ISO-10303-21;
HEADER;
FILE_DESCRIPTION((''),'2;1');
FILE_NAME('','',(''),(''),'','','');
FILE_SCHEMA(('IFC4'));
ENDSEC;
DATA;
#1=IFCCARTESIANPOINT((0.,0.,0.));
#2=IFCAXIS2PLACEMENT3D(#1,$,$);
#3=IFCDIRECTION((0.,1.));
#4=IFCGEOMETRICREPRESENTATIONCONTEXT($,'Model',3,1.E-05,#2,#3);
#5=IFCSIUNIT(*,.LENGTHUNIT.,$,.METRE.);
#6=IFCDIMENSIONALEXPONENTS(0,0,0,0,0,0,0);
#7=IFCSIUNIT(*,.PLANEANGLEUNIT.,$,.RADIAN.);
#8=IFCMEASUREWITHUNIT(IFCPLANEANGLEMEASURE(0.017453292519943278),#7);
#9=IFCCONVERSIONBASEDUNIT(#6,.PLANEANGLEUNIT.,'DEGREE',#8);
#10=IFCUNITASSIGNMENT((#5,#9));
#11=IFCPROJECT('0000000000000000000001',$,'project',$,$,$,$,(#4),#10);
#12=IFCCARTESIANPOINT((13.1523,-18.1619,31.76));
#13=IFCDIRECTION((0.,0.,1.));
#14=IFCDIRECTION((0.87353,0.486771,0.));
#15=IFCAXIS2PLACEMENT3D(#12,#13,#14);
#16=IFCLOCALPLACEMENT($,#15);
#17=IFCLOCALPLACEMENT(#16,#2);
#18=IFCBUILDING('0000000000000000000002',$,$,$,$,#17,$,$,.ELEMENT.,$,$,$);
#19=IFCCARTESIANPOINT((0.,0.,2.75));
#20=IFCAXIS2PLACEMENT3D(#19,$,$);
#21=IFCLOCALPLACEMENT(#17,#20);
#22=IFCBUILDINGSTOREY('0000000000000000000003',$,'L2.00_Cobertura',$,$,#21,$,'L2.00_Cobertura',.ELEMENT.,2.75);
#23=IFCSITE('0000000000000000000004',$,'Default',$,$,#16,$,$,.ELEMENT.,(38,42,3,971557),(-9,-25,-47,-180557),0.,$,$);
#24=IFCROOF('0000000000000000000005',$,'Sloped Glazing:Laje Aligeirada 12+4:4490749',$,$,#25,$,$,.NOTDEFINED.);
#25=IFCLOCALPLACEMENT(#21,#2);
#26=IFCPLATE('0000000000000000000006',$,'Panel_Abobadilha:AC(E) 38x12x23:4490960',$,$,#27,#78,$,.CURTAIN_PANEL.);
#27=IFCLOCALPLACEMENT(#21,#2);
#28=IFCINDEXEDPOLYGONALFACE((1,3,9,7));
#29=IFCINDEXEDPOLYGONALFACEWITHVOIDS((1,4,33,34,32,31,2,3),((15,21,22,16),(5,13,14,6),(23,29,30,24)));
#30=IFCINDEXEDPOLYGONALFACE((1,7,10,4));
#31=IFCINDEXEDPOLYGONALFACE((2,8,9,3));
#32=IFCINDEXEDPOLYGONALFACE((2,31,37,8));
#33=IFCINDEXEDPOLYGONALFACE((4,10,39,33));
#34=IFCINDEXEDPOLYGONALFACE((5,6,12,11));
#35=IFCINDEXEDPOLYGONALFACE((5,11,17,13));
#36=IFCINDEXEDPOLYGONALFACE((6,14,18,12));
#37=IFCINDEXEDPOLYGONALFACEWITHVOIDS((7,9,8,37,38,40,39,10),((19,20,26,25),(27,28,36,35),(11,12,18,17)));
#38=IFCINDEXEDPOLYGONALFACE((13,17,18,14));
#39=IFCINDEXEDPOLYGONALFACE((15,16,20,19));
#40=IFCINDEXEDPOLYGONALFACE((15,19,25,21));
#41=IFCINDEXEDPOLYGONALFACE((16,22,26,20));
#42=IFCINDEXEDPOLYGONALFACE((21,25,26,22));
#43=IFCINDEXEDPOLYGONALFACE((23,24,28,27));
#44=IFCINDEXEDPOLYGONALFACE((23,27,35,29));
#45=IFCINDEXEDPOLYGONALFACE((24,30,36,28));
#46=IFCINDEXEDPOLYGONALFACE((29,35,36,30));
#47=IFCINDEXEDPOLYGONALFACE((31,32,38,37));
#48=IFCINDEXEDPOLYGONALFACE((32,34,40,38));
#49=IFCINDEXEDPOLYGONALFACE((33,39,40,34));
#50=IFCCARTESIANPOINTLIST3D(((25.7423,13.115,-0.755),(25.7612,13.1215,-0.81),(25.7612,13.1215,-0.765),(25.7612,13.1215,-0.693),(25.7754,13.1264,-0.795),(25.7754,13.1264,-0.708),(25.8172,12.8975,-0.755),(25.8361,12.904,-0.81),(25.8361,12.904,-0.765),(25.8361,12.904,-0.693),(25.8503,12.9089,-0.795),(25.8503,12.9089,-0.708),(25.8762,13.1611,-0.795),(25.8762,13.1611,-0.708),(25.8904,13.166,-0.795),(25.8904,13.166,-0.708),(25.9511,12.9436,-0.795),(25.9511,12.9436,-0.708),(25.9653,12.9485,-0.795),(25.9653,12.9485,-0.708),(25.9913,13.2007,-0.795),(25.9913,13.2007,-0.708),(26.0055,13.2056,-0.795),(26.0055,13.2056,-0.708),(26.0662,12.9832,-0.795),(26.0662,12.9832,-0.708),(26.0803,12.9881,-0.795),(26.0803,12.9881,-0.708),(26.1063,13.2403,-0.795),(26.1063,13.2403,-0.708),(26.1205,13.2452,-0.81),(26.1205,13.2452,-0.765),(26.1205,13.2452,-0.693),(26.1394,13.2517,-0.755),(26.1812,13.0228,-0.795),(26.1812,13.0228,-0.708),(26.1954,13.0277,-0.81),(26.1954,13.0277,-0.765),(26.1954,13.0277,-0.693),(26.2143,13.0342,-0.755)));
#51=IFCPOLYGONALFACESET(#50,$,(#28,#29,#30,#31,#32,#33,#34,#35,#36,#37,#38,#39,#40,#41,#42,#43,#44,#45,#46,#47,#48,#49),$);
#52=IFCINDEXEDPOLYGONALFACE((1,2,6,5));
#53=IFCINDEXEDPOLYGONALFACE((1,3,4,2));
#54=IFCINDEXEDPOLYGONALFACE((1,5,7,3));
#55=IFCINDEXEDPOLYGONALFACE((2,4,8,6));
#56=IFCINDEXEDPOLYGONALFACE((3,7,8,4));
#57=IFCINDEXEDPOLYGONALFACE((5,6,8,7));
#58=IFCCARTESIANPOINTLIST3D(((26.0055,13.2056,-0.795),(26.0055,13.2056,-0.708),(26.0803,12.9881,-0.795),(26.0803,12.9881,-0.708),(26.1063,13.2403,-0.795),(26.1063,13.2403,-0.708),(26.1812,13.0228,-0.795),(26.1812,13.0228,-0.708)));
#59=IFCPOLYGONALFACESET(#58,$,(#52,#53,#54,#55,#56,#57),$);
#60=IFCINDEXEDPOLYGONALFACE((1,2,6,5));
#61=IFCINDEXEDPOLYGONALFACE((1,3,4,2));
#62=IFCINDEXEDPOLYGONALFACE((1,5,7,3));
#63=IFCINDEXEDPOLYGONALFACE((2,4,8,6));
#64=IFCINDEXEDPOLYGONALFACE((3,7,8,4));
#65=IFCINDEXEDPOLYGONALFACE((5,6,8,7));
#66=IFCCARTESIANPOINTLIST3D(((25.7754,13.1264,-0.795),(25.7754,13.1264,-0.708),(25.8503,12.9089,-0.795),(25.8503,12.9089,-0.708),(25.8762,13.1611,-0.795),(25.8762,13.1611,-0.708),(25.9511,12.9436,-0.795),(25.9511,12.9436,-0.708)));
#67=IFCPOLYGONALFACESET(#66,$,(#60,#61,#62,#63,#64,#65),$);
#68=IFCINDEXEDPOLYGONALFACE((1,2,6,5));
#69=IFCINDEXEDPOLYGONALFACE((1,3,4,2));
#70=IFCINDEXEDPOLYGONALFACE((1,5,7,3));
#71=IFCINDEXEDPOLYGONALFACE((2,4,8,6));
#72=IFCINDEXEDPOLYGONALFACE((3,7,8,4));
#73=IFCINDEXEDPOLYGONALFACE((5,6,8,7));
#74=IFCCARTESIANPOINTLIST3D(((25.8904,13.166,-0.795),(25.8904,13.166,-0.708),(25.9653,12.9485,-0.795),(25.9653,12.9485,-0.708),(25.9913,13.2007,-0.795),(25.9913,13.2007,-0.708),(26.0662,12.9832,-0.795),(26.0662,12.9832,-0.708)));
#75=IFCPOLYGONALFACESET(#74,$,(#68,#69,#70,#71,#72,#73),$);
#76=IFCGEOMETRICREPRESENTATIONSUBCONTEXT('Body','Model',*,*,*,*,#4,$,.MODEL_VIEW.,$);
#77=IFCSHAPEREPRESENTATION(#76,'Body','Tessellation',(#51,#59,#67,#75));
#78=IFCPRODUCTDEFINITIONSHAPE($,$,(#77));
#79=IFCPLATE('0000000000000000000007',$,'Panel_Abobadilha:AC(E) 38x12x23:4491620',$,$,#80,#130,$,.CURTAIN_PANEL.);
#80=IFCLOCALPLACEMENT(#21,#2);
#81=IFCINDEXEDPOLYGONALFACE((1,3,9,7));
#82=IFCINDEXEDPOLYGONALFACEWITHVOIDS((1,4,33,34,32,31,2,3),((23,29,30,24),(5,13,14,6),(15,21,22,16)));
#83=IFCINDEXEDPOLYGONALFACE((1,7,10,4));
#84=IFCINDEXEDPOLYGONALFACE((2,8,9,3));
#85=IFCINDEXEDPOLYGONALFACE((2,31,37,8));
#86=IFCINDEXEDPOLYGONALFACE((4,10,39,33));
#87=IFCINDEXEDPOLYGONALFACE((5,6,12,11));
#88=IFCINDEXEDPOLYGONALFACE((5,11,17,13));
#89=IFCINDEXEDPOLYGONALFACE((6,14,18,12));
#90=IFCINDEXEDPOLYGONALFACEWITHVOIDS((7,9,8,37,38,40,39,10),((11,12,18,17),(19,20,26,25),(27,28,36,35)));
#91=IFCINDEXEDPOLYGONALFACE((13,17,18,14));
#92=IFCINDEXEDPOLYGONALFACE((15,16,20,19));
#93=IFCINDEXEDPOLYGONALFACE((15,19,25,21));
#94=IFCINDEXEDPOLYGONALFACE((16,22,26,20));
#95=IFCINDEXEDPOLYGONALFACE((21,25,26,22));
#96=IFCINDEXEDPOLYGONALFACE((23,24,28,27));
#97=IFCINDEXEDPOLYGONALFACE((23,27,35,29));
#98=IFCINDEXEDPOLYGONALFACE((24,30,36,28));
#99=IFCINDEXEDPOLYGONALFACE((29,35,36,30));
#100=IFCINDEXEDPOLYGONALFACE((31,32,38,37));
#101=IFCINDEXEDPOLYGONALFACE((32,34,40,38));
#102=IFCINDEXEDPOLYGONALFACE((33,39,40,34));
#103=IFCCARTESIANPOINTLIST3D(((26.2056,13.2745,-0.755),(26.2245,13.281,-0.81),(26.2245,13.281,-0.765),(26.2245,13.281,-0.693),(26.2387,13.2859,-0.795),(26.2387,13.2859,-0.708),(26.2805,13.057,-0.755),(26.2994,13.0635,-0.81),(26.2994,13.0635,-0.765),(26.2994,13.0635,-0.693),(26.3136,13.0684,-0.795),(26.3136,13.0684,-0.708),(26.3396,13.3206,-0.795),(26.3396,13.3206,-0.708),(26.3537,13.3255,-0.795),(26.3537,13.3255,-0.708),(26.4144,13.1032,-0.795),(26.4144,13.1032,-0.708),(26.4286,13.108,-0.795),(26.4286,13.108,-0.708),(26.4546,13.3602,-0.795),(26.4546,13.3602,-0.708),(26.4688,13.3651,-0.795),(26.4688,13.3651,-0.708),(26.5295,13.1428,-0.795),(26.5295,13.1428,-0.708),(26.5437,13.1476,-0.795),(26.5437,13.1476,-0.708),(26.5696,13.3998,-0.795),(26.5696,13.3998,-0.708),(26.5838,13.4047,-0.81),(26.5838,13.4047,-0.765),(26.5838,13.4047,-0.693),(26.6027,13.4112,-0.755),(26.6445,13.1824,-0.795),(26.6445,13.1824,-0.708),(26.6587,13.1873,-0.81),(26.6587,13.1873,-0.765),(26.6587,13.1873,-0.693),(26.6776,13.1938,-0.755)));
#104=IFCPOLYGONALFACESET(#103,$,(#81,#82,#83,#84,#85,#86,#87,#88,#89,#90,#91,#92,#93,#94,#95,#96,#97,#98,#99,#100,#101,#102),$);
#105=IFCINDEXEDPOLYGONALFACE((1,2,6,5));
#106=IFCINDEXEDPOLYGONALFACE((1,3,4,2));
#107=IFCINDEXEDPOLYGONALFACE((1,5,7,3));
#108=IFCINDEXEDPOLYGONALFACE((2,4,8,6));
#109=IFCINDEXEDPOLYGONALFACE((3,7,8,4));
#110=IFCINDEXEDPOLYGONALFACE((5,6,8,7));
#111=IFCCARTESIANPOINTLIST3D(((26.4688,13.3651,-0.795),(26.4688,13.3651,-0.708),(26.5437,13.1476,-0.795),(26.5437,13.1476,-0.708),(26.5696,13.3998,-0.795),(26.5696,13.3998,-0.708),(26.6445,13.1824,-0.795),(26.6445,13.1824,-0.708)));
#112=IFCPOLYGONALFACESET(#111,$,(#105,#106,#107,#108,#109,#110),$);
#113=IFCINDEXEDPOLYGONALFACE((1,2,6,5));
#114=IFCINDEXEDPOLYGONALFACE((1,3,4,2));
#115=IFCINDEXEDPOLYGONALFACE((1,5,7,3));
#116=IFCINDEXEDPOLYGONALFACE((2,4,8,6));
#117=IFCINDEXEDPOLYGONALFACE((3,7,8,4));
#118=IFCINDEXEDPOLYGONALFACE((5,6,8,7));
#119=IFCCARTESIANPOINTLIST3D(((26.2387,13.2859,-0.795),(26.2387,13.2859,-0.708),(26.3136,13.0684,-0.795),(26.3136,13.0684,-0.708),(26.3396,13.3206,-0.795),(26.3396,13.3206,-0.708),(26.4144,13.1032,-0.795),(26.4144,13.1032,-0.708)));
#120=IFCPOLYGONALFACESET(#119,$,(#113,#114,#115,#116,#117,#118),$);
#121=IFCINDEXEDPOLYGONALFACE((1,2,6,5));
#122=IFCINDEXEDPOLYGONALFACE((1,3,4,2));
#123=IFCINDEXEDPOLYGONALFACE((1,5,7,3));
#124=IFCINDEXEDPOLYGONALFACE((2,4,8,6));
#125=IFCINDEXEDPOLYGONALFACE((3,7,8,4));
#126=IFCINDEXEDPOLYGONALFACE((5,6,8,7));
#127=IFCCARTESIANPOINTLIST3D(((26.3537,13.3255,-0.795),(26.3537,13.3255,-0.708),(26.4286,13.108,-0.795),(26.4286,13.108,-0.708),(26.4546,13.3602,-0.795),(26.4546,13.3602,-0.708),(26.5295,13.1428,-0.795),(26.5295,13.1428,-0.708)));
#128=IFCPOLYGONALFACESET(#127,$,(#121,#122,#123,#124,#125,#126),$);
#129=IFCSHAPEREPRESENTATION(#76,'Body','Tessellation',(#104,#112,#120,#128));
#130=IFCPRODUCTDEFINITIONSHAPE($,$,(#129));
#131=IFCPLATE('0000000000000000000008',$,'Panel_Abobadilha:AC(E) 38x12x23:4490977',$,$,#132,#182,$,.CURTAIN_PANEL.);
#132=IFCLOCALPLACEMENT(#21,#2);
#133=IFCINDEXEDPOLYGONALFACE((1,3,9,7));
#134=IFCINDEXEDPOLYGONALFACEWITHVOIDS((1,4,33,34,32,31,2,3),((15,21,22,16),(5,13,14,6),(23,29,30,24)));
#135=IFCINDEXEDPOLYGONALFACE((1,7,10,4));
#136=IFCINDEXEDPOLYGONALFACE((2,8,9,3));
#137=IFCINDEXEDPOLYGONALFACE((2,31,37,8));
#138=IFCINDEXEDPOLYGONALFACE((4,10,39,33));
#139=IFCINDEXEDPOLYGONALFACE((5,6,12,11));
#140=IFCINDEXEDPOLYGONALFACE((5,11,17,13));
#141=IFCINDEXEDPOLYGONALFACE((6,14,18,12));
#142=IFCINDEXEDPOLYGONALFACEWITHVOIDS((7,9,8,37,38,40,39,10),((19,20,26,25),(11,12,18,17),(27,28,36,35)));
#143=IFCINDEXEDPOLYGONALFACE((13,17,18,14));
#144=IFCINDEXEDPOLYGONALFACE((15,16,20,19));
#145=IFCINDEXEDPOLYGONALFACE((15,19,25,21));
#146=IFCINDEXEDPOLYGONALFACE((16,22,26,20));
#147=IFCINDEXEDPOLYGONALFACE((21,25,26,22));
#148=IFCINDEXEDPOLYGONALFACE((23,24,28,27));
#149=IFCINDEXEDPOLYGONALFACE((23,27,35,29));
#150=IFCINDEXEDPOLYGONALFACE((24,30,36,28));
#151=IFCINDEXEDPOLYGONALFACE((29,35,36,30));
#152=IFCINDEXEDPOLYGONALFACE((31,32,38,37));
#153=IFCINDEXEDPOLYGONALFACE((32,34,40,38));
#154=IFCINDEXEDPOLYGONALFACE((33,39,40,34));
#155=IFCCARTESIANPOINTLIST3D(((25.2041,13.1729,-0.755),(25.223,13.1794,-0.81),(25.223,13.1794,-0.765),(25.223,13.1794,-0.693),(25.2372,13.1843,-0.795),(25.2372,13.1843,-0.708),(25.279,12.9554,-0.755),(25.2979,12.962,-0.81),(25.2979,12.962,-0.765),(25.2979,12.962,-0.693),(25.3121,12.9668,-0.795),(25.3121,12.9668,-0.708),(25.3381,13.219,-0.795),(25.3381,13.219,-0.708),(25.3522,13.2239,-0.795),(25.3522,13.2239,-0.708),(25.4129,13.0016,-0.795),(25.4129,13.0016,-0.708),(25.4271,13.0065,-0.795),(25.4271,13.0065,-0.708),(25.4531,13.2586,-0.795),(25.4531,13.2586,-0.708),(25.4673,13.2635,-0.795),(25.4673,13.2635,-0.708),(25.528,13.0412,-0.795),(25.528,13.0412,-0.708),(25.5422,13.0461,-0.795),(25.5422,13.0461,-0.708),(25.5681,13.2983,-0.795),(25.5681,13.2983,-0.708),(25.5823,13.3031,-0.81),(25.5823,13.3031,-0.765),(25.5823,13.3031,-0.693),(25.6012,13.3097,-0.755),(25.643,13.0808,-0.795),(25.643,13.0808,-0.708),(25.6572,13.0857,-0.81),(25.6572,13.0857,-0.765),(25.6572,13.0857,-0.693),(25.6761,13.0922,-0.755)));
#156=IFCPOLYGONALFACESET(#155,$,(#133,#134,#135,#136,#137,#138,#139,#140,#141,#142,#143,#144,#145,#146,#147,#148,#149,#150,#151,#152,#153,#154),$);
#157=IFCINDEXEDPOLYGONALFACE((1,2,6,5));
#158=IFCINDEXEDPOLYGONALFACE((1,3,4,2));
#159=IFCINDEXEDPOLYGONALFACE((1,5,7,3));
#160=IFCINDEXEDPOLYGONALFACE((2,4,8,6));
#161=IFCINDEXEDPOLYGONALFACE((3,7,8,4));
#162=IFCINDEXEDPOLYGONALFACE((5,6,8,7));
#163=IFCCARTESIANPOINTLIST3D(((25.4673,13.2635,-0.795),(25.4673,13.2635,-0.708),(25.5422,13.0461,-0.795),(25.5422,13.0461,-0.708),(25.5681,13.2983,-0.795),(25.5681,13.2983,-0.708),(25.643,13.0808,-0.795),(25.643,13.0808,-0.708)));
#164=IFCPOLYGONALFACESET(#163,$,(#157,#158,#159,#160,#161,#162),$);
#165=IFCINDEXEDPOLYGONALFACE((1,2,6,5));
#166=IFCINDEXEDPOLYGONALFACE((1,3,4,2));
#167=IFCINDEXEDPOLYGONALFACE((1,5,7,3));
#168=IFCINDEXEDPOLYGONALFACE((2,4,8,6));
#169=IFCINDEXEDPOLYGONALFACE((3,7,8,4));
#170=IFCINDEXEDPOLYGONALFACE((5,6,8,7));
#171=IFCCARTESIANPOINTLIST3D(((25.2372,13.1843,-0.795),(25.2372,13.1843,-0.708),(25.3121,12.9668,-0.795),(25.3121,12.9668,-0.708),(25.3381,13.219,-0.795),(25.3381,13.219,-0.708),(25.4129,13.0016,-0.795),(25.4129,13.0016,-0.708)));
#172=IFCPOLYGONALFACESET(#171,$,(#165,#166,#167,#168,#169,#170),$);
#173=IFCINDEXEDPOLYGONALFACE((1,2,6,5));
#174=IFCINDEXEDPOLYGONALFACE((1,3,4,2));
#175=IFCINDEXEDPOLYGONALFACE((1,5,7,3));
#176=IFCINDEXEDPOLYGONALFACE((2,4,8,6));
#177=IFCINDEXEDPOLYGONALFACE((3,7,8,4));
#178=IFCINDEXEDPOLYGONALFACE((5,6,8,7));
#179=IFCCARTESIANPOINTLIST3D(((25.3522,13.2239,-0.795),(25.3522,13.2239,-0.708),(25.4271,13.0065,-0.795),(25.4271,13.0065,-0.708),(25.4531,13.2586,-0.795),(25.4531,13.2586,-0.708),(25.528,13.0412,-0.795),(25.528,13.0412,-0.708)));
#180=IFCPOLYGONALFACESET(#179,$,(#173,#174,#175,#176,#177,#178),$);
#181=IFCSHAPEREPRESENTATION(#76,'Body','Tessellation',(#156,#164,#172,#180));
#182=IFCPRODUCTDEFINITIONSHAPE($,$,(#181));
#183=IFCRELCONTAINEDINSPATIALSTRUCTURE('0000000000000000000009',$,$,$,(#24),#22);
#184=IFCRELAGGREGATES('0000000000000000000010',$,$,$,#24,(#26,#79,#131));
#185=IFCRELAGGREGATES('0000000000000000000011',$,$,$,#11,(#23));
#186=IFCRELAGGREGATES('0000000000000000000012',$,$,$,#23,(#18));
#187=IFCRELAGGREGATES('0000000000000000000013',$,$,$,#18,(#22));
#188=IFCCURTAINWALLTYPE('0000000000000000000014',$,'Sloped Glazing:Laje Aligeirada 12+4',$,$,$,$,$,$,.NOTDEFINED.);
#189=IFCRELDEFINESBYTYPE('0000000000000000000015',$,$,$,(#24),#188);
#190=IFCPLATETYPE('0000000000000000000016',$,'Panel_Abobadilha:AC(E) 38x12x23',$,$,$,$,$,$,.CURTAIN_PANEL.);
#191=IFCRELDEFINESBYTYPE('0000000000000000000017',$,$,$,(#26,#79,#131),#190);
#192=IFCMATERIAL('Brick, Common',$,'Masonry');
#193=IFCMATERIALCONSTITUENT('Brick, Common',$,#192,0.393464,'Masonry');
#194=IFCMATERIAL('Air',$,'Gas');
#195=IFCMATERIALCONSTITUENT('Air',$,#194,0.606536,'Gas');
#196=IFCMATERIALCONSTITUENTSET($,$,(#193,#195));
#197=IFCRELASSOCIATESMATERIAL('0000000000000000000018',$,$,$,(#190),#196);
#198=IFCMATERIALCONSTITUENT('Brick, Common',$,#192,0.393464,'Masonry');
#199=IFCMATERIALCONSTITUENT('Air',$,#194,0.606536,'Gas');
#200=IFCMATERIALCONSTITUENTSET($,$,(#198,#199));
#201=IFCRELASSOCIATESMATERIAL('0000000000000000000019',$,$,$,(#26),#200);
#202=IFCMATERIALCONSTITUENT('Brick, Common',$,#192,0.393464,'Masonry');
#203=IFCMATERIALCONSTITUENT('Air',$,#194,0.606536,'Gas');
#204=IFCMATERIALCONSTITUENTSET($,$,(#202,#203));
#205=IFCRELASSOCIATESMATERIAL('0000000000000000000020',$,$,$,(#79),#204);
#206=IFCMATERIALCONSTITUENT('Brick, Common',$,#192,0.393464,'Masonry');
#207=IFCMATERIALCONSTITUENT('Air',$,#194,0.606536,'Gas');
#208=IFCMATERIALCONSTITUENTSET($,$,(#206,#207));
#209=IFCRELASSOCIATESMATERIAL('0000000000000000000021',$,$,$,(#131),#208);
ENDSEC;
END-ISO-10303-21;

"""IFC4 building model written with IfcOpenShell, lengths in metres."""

from ifc_helpers import new_model, entity, si_unit, converted_unit, direction, frame, origin, place, context, subcontext, project, spatial, indexed_curve, outline, extrude, source, transform, mapped, material, constituent, constituent_set, type_object, type_shapes, element, aggregate, save


model = new_model("IFC4")

# Units and contexts
model_context = context("Model", 3, precision=1e-05, world=origin(), true_north=direction((0.0, 1.0)))
body_context = subcontext(model_context, "Body", "Model", "MODEL_VIEW")
ifc_project = project(units=[si_unit("LENGTHUNIT", "METRE"), converted_unit("PLANEANGLEUNIT", "DEGREE", entity("IfcPlaneAngleMeasure", 0.017453292519943278), si_unit("PLANEANGLEUNIT", "RADIAN"), dimensions=[0, 0, 0, 0, 0, 0, 0])], contexts=[model_context])

# Site, building, storey
site_placement = place(None, frame((13.1523, -18.1619, 31.76), z_axis=(0.0, 0.0, 1.0), x_axis=(0.87353, 0.486771, 0.0)))
site = spatial("IfcSite", under=ifc_project, at=site_placement, Name="Default", CompositionType="ELEMENT", RefLatitude=(38, 42, 3, 971557), RefLongitude=(-9, -25, -47, -180557), RefElevation=0.0)
building_placement = place(site_placement, origin())
building = spatial("IfcBuilding", under=site, at=building_placement, CompositionType="ELEMENT")
storey_placement = place(building_placement, frame((0.0, 0.0, 2.75)))
storey = spatial("IfcBuildingStorey", under=building, at=storey_placement, Name="L2.00_Cobertura", LongName="L2.00_Cobertura", CompositionType="ELEMENT", Elevation=2.75)

# Roof, plates
curtain_wall_type = type_object("IfcCurtainWallType", Name="Sloped Glazing:Laje Aligeirada 12+4", PredefinedType="NOTDEFINED")
roof_placement = place(storey_placement, frame((0.0, 0.0, -2.75)))
roof = element("IfcRoof", 1, at=roof_placement, inside=storey, type_object=curtain_wall_type, Name="Sloped Glazing:Laje Aligeirada 12+4:4490749", PredefinedType="NOTDEFINED")
ifc_material_1 = material(Name="Brick, Common", Category="Masonry")
ifc_material_2 = material(Name="Air", Category="Gas")
ifc_constituent_1 = constituent(ifc_material_1, Name="Brick, Common", Category="Masonry", fraction=0.393464)
ifc_constituent_2 = constituent(ifc_material_2, Name="Air", Category="Gas", fraction=0.606536)
ifc_constituent_set_1 = constituent_set(constituents=[ifc_constituent_1, ifc_constituent_2])
plate_type = type_object("IfcPlateType", Name="Panel_Abobadilha:AC(E) 38x12x23", PredefinedType="CURTAIN_PANEL", material=ifc_constituent_set_1)
shared_shape_1 = source(origin(), body_context, "Body", "SweptSolid", [
    extrude(outline(indexed_curve([(-0.19, -0.0543), (0.19, -0.0543), (0.19, -0.0093), (0.21, 0.0007), (0.19, 0.0628), (-0.19, 0.0628), (-0.21, 0.0007), (-0.19, -0.0093), (-0.19, -0.0543)], self_intersect=False), holes=[indexed_curve([(-0.0683, 0.0477), (-0.0683, -0.0393), (-0.175, -0.0393), (-0.175, 0.0477), (-0.0683, 0.0477)], self_intersect=False), indexed_curve([(0.0533, 0.0477), (0.0533, -0.0393), (-0.0533, -0.0393), (-0.0533, 0.0477), (0.0533, 0.0477)], self_intersect=False), indexed_curve([(0.175, 0.0477), (0.175, -0.0393), (0.0683, -0.0393), (0.0683, 0.0477), (0.175, 0.0477)], self_intersect=False)]), frame((0.0, 0.0543, 0.0)), (0.0, 0.0, 1.0), 0.23),
    extrude(outline(indexed_curve([(-0.0533, -0.0435), (0.0533, -0.0435), (0.0533, 0.0435), (-0.0533, 0.0435), (-0.0533, -0.0435)], self_intersect=False)), frame((0.1217, 0.0585, 0.0), z_axis=(0.0, 0.0, 1.0), x_axis=(-1.0, 0.0, 0.0)), (0.0, 0.0, 1.0), 0.23),
    extrude(outline(indexed_curve([(-0.0533, -0.0435), (0.0533, -0.0435), (0.0533, 0.0435), (-0.0533, 0.0435), (-0.0533, -0.0435)], self_intersect=False)), frame((-0.1217, 0.0585, 0.0), z_axis=(0.0, 0.0, 1.0), x_axis=(-1.0, 0.0, 0.0)), (0.0, 0.0, 1.0), 0.23),
    extrude(outline(indexed_curve([(-0.0533, -0.0435), (0.0533, -0.0435), (0.0533, 0.0435), (-0.0533, 0.0435), (-0.0533, -0.0435)], self_intersect=False)), frame((0.0, 0.0585, 0.0), z_axis=(0.0, 0.0, 1.0), x_axis=(-1.0, 0.0, 0.0)), (0.0, 0.0, 1.0), 0.23),
])
type_shapes(plate_type, [shared_shape_1])
ifc_constituent_3 = constituent(ifc_material_1, Name="Brick, Common", Category="Masonry", fraction=0.393464)
ifc_constituent_4 = constituent(ifc_material_2, Name="Air", Category="Gas", fraction=0.606536)
ifc_constituent_set_2 = constituent_set(constituents=[ifc_constituent_3, ifc_constituent_4])
plate_1_placement = place(roof_placement, frame((25.9409, 13.1833, 1.94), z_axis=(0.325568, -0.945519, 0.0), x_axis=(0.945519, 0.325568, 0.0)))
plate_1 = element("IfcPlate", 2, at=plate_1_placement, type_object=plate_type, material=ifc_constituent_set_2, Name="Panel_Abobadilha:AC(E) 38x12x23:4490960", PredefinedType="CURTAIN_PANEL", context=body_context, shape_type="MappedRepresentation", body=[
    mapped(shared_shape_1, transform((0.0, 0.0, 0.0), scale=1.0)),
])
ifc_constituent_5 = constituent(ifc_material_1, Name="Brick, Common", Category="Masonry", fraction=0.393464)
ifc_constituent_6 = constituent(ifc_material_2, Name="Air", Category="Gas", fraction=0.606536)
ifc_constituent_set_3 = constituent_set(constituents=[ifc_constituent_5, ifc_constituent_6])
plate_2_placement = place(roof_placement, frame((26.4042, 13.3429, 1.94), z_axis=(0.325568, -0.945519, 0.0), x_axis=(0.945519, 0.325568, 0.0)))
plate_2 = element("IfcPlate", 3, at=plate_2_placement, type_object=plate_type, material=ifc_constituent_set_3, Name="Panel_Abobadilha:AC(E) 38x12x23:4491620", PredefinedType="CURTAIN_PANEL", context=body_context, shape_type="MappedRepresentation", body=[
    mapped(shared_shape_1, transform((0.0, 0.0, 0.0), scale=1.0)),
])
ifc_constituent_7 = constituent(ifc_material_1, Name="Brick, Common", Category="Masonry", fraction=0.393464)
ifc_constituent_8 = constituent(ifc_material_2, Name="Air", Category="Gas", fraction=0.606536)
ifc_constituent_set_4 = constituent_set(constituents=[ifc_constituent_7, ifc_constituent_8])
plate_3_placement = place(roof_placement, frame((25.4027, 13.2413, 1.94), z_axis=(0.325568, -0.945519, 0.0), x_axis=(0.945519, 0.325568, 0.0)))
plate_3 = element("IfcPlate", 4, at=plate_3_placement, type_object=plate_type, material=ifc_constituent_set_4, Name="Panel_Abobadilha:AC(E) 38x12x23:4490977", PredefinedType="CURTAIN_PANEL", context=body_context, shape_type="MappedRepresentation", body=[
    mapped(shared_shape_1, transform((0.0, 0.0, 0.0), scale=1.0)),
])
aggregate(roof, [plate_1, plate_2, plate_3])

save(model, "model.ifc")
